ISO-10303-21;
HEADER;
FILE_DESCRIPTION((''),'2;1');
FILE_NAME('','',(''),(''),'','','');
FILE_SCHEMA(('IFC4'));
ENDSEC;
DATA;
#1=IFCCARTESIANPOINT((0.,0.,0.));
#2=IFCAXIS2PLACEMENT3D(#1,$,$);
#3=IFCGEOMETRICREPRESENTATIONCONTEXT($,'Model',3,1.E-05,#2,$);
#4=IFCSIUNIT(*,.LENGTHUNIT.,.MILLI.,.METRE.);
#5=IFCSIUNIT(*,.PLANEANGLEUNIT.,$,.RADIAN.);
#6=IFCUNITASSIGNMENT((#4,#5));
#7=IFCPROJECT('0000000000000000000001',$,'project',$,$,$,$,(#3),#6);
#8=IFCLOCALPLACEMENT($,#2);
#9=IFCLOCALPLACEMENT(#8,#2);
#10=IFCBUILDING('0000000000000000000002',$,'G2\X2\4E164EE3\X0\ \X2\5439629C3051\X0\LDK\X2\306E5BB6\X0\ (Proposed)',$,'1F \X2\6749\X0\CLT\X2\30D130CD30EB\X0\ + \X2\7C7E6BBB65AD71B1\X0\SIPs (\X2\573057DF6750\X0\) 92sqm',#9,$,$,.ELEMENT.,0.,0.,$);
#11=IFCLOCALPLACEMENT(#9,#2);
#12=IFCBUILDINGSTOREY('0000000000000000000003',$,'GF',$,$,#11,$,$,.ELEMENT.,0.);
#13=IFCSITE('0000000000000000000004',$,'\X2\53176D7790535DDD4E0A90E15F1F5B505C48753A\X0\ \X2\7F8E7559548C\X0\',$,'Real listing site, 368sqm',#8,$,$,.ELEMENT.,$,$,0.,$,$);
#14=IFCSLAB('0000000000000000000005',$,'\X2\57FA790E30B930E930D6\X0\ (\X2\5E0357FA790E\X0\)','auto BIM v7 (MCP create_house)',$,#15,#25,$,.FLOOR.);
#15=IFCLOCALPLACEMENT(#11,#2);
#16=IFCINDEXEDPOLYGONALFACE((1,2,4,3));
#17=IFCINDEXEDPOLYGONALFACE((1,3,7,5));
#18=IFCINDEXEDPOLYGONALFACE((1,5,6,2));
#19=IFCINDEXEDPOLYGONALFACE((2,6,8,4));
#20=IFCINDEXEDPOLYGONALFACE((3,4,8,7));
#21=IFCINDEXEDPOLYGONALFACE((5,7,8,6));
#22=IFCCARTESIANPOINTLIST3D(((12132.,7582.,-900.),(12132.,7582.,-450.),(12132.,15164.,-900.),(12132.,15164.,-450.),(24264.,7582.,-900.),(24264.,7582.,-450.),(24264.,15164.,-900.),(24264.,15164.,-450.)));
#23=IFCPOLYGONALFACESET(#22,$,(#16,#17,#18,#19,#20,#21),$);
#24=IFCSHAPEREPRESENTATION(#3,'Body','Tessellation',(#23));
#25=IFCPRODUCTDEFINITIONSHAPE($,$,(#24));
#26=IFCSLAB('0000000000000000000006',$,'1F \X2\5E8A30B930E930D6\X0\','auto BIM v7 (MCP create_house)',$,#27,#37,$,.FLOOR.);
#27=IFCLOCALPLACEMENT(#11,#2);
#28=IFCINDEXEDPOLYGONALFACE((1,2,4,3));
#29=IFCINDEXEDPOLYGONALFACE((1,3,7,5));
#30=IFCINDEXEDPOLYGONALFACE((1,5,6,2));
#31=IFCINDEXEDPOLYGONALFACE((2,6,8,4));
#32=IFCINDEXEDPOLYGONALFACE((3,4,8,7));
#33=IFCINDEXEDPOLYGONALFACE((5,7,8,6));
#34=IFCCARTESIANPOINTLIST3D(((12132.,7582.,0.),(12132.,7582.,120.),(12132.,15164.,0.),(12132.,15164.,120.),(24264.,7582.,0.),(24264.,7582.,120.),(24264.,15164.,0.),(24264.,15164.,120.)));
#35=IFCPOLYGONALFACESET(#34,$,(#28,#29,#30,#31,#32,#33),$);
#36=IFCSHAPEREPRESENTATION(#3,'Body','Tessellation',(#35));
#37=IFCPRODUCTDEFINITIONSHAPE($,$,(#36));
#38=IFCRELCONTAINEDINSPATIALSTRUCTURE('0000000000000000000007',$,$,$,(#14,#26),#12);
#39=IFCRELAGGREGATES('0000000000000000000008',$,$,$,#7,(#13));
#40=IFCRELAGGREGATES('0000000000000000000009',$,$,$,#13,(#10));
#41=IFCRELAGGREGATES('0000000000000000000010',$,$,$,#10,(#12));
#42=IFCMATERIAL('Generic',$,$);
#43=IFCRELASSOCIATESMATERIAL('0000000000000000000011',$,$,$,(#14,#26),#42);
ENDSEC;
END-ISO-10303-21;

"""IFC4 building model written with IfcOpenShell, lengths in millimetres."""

from ifc_helpers import new_model, si_unit, frame, frame_2d, origin, place, context, project, spatial, rectangle, extrude, material, element, save


model = new_model("IFC4")

# Units and contexts
model_context = context("Model", 3, precision=1e-05, world=origin())
ifc_project = project(units=[si_unit("LENGTHUNIT", "METRE", prefix="MILLI"), si_unit("PLANEANGLEUNIT", "RADIAN")], contexts=[model_context])

# Site, building, storey
site_placement = place(None, origin())
site = spatial("IfcSite", under=ifc_project, at=site_placement, Name="北海道川上郡弟子屈町 美留和", ObjectType="Real listing site, 368sqm", CompositionType="ELEMENT", RefElevation=0.0)
building_placement = place(site_placement, origin())
building = spatial("IfcBuilding", under=site, at=building_placement, Name="G2世代 吹抜けLDKの家 (Proposed)", ObjectType="1F 杉CLTパネル + 籾殻断熱SIPs (地域材) 92sqm", CompositionType="ELEMENT", ElevationOfRefHeight=0.0, ElevationOfTerrain=0.0)
storey_placement = place(building_placement, origin())
storey = spatial("IfcBuildingStorey", under=building, at=storey_placement, Name="GF", CompositionType="ELEMENT", Elevation=0.0)

# Slabs
ifc_material = material(Name="Generic")
slab_1_placement = place(storey_placement, frame((6066.0, 3791.0, -450.0)))
element("IfcSlab", 1, at=slab_1_placement, inside=storey, material=ifc_material, Name="基礎スラブ (布基礎)", Description="auto BIM v7 (MCP create_house)", PredefinedType="FLOOR", context=model_context, shape_type="SweptSolid", body=[
    extrude(rectangle(XDim=12132.0, YDim=7582.0, at=frame_2d((6066.0, 3791.0))), frame((6066.0, 3791.0, -450.0)), (0.0, 0.0, 1.0), 450.0),
])
slab_2_placement = place(storey_placement, frame((6066.0, 3791.0, 0.0)))
element("IfcSlab", 2, at=slab_2_placement, inside=storey, material=ifc_material, Name="1F 床スラブ", Description="auto BIM v7 (MCP create_house)", PredefinedType="FLOOR", context=model_context, shape_type="SweptSolid", body=[
    extrude(rectangle(XDim=12132.0, YDim=7582.0, at=frame_2d((6066.0, 3791.0))), frame((6066.0, 3791.0, 0.0)), (0.0, 0.0, 1.0), 120.0),
])

save(model, "model.ifc")
